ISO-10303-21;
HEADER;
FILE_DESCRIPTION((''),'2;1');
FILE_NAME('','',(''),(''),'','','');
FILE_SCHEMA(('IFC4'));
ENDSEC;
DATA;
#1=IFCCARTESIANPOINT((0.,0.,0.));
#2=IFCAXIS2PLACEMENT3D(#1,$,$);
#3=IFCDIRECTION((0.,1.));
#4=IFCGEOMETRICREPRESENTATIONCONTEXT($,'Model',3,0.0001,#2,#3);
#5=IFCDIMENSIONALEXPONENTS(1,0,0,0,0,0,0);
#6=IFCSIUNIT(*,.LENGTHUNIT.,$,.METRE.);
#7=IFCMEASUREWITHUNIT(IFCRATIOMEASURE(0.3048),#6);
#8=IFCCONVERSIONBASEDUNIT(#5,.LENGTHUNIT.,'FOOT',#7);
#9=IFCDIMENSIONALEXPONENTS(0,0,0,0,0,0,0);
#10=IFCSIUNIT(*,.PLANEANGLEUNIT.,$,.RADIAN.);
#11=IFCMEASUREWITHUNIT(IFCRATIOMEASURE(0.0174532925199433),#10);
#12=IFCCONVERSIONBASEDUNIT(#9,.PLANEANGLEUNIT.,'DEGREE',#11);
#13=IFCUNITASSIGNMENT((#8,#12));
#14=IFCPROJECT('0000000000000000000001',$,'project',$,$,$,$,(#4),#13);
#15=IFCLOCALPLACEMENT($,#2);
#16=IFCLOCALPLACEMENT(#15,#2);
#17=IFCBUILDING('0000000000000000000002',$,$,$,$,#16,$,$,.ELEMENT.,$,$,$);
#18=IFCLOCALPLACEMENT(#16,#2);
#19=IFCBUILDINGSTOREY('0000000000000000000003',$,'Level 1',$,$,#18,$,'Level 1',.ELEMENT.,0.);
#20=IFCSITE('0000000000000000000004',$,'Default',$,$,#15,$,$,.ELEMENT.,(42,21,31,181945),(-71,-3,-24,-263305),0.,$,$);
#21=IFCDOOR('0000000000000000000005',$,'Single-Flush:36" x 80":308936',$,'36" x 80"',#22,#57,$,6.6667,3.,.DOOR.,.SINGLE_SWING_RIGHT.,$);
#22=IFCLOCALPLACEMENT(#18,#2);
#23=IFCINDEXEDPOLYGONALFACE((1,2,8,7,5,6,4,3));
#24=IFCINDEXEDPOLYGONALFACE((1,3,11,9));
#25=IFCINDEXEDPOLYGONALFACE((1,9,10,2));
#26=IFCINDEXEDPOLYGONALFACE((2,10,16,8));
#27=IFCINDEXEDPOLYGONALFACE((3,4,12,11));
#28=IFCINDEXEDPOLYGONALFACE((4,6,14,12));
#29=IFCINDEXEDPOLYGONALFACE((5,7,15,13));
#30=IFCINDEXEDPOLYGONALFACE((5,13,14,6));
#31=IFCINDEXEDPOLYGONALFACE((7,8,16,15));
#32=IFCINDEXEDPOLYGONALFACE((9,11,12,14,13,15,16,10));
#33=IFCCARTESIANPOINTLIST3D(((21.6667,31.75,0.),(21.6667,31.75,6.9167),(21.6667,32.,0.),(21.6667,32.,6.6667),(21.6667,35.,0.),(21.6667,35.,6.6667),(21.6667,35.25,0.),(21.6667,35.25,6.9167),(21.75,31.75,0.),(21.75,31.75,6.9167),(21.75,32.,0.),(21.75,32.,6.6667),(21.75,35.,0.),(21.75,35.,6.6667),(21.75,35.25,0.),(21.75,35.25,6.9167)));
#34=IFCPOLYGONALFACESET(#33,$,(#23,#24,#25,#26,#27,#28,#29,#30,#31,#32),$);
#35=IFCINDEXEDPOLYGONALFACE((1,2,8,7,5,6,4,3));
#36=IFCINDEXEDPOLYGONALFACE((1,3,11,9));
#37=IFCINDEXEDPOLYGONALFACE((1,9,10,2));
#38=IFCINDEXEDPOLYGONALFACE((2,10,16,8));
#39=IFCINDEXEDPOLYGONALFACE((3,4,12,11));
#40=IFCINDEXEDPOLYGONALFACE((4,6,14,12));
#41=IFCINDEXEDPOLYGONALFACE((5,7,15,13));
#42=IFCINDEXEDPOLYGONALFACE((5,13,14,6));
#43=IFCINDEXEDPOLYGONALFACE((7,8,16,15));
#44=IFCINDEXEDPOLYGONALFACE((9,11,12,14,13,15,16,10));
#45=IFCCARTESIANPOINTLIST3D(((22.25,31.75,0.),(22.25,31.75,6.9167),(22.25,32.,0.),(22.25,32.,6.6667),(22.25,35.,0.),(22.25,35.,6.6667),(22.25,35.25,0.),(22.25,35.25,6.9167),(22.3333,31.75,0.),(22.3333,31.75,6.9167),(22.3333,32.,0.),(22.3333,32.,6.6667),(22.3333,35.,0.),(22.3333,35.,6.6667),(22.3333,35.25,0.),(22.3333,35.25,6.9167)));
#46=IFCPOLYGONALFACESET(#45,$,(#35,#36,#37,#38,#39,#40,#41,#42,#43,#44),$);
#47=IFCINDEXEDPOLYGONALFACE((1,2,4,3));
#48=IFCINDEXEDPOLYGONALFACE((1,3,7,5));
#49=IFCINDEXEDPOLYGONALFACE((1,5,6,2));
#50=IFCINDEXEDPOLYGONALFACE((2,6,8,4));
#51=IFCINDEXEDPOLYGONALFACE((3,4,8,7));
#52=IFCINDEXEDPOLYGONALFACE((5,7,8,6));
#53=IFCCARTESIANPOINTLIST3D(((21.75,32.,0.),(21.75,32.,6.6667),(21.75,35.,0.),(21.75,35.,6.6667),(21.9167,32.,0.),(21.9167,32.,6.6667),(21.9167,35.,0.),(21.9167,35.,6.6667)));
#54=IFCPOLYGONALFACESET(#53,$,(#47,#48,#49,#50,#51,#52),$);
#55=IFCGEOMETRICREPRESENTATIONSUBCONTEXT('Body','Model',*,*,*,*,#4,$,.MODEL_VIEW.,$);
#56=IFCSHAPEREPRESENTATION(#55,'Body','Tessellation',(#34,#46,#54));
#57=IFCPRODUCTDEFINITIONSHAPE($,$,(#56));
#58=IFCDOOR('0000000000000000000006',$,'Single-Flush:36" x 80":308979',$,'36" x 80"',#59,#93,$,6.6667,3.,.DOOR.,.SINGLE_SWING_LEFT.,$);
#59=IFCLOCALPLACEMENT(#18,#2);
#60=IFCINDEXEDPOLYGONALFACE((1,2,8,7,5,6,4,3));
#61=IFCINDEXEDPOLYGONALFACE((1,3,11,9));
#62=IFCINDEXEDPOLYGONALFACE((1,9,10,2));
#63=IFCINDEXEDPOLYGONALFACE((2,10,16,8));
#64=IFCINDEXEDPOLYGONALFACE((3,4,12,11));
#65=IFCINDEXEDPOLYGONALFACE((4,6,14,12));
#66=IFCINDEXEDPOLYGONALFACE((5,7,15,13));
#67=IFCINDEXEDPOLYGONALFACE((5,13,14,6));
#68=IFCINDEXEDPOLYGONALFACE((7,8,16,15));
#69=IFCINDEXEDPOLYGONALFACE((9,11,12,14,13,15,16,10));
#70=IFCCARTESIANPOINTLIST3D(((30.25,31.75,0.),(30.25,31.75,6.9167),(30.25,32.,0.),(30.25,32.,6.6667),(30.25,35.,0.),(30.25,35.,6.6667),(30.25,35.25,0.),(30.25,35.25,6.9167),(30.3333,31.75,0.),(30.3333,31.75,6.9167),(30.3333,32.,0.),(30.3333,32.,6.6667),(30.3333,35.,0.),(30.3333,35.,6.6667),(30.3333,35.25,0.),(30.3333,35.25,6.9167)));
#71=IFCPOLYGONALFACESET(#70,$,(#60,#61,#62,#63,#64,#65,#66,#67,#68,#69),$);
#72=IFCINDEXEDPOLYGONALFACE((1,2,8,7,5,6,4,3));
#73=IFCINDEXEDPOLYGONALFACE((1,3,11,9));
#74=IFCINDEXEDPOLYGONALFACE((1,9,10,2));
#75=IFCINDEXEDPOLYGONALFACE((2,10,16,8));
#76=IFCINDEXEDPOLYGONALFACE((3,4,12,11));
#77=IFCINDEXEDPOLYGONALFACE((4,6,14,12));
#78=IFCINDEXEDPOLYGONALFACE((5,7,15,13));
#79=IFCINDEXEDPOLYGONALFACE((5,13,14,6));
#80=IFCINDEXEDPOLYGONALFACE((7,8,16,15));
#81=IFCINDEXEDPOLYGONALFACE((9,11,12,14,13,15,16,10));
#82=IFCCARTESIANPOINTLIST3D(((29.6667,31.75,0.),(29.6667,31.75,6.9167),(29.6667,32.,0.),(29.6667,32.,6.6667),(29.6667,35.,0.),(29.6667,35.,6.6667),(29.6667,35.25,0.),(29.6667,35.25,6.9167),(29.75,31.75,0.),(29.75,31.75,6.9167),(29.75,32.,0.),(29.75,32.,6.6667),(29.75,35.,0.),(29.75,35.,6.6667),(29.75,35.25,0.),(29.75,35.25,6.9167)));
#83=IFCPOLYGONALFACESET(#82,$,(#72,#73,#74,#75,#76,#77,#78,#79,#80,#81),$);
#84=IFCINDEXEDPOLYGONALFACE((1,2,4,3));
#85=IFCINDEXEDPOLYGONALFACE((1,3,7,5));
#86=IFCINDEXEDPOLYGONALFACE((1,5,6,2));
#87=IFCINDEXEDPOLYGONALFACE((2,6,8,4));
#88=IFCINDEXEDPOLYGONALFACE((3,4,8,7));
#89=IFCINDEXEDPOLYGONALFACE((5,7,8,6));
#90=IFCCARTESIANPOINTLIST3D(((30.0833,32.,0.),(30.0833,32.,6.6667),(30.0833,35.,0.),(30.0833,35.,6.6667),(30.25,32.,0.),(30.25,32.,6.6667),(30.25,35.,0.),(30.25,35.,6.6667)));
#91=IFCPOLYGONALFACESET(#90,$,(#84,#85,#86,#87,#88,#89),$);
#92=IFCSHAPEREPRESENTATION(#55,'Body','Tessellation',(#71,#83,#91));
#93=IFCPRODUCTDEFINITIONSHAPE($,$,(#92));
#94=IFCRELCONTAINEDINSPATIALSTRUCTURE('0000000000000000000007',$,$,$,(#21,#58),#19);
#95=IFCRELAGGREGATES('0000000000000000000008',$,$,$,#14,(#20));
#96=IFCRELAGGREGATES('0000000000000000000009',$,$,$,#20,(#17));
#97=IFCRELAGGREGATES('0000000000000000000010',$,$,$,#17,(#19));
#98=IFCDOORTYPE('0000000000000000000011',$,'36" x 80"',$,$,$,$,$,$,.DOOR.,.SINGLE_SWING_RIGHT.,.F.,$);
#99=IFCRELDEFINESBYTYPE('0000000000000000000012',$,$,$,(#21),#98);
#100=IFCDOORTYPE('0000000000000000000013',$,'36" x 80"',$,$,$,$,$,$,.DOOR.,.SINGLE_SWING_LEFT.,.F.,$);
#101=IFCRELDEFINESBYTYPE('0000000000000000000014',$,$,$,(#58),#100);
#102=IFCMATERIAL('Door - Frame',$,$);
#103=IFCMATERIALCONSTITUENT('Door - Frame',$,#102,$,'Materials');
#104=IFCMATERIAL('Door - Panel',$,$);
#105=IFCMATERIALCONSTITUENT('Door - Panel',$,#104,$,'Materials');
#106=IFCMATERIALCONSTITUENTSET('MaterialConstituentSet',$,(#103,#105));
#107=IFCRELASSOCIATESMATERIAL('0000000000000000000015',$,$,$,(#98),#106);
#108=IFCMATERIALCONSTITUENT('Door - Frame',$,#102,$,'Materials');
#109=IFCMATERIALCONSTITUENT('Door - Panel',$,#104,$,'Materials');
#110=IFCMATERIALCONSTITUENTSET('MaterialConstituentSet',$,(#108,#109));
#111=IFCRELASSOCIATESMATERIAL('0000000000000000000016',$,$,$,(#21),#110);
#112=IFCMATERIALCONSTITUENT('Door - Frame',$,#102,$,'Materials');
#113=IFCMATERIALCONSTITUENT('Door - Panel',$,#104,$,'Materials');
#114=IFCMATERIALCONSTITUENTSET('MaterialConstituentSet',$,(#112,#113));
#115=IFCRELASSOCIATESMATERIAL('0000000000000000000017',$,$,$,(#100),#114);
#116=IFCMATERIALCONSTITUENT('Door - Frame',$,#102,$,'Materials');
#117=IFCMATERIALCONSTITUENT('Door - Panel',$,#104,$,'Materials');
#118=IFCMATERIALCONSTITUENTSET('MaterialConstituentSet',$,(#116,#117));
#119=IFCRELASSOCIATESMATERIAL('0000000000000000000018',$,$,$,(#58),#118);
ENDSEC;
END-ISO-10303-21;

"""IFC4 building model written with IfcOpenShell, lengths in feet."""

from ifc_helpers import new_model, entity, si_unit, converted_unit, direction, frame, origin, origin_2d_with_axis, place, context, subcontext, project, spatial, polyline, rectangle, outline, extrude, source, transform, mapped, material, constituent, constituent_set, type_object, type_shapes, element, save


model = new_model("IFC4")

# Units and contexts
model_context = context("Model", 3, precision=0.0001, world=origin(), true_north=direction((0.0, 1.0)))
body_context = subcontext(model_context, "Body", "Model", "MODEL_VIEW")
ifc_project = project(units=[converted_unit("LENGTHUNIT", "FOOT", entity("IfcRatioMeasure", 0.3048), si_unit("LENGTHUNIT", "METRE"), dimensions=[1, 0, 0, 0, 0, 0, 0]), converted_unit("PLANEANGLEUNIT", "DEGREE", entity("IfcRatioMeasure", 0.0174532925199433), si_unit("PLANEANGLEUNIT", "RADIAN"), dimensions=[0, 0, 0, 0, 0, 0, 0])], contexts=[model_context])

# Site, building, storey
site_placement = place(None, origin())
site = spatial("IfcSite", under=ifc_project, at=site_placement, Name="Default", CompositionType="ELEMENT", RefLatitude=(42, 21, 31, 181945), RefLongitude=(-71, -3, -24, -263305), RefElevation=0.0)
building_placement = place(site_placement, origin())
building = spatial("IfcBuilding", under=site, at=building_placement, CompositionType="ELEMENT")
storey_placement = place(building_placement, origin())
storey = spatial("IfcBuildingStorey", under=building, at=storey_placement, Name="Level 1", LongName="Level 1", CompositionType="ELEMENT", Elevation=0.0)

# Shared definitions
placement_1 = place(storey_placement, frame((30.0, 45.75, 0.0), z_axis=(0.0, 0.0, 1.0), x_axis=(0.0, -1.0, 0.0)))

# Shared definitions
placement_2 = place(storey_placement, frame((22.0, 45.75, 0.0), z_axis=(0.0, 0.0, 1.0), x_axis=(0.0, -1.0, 0.0)))

# Doors
ifc_material_1 = material(Name="Door - Frame")
ifc_constituent_1 = constituent(ifc_material_1, Name="Door - Frame", Category="Materials")
ifc_material_2 = material(Name="Door - Panel")
ifc_constituent_2 = constituent(ifc_material_2, Name="Door - Panel", Category="Materials")
ifc_constituent_set_1 = constituent_set(constituents=[ifc_constituent_1, ifc_constituent_2], Name="MaterialConstituentSet")
ifc_constituent_3 = constituent(ifc_material_1, Name="Door - Frame", Category="Materials")
ifc_constituent_4 = constituent(ifc_material_2, Name="Door - Panel", Category="Materials")
ifc_constituent_set_2 = constituent_set(constituents=[ifc_constituent_3, ifc_constituent_4], Name="MaterialConstituentSet")
door_type_1 = type_object("IfcDoorType", Name="36\" x 80\"", OperationType="SINGLE_SWING_RIGHT", ParameterTakesPrecedence=False, PredefinedType="DOOR", material=ifc_constituent_set_2)
shared_shape_1 = source(origin(), body_context, "Body", "SweptSolid", [
    extrude(outline(polyline([(-1.75, -3.5208), (1.75, -3.5208), (1.75, 3.3958), (1.5, 3.3958), (1.5, -3.2708), (-1.5, -3.2708), (-1.5, 3.3958), (-1.75, 3.3958), (-1.75, -3.5208)])), frame((1.5, 0.5, 3.3958), z_axis=(0.0, 1.0, 0.0), x_axis=(1.0, 0.0, 0.0)), (0.0, 0.0, 1.0), 0.0833),
    extrude(outline(polyline([(-3.5208, -1.75), (3.3958, -1.75), (3.3958, -1.5), (-3.2708, -1.5), (-3.2708, 1.5), (3.3958, 1.5), (3.3958, 1.75), (-3.5208, 1.75), (-3.5208, -1.75)])), frame((1.5, -0.0833, 3.3958), z_axis=(0.0, 1.0, 0.0), x_axis=(0.0, 0.0, -1.0)), (0.0, 0.0, 1.0), 0.0833),
    extrude(rectangle(XDim=0.1667, YDim=3.0, at=origin_2d_with_axis()), frame((1.5, 0.4167, 0.0), z_axis=(0.0, 0.0, 1.0), x_axis=(0.0, 1.0, 0.0)), (0.0, 0.0, 1.0), 6.6667),
])
type_shapes(door_type_1, [shared_shape_1])
placement_3 = place(placement_2, frame((13.75, 0.25, 0.0)))
door_1_placement = place(placement_3, frame((0.0, 0.0, 0.0), z_axis=(0.0, 0.0, 1.0), x_axis=(-1.0, 0.0, 0.0)))
element("IfcDoor", 1, at=door_1_placement, inside=storey, type_object=door_type_1, material=ifc_constituent_set_1, Name="Single-Flush:36\" x 80\":308936", ObjectType="36\" x 80\"", OperationType="SINGLE_SWING_RIGHT", OverallHeight=6.6667, OverallWidth=3.0, PredefinedType="DOOR", context=body_context, shape_type="MappedRepresentation", body=[
    mapped(shared_shape_1, transform((0.0, 0.0, 0.0), scale=1.0)),
])
ifc_constituent_5 = constituent(ifc_material_1, Name="Door - Frame", Category="Materials")
ifc_constituent_6 = constituent(ifc_material_2, Name="Door - Panel", Category="Materials")
ifc_constituent_set_3 = constituent_set(constituents=[ifc_constituent_5, ifc_constituent_6], Name="MaterialConstituentSet")
ifc_constituent_7 = constituent(ifc_material_1, Name="Door - Frame", Category="Materials")
ifc_constituent_8 = constituent(ifc_material_2, Name="Door - Panel", Category="Materials")
ifc_constituent_set_4 = constituent_set(constituents=[ifc_constituent_7, ifc_constituent_8], Name="MaterialConstituentSet")
door_type_2 = type_object("IfcDoorType", Name="36\" x 80\"", OperationType="SINGLE_SWING_LEFT", ParameterTakesPrecedence=False, PredefinedType="DOOR", material=ifc_constituent_set_4)
shared_shape_2 = source(origin(), body_context, "Body", "SweptSolid", [
    extrude(outline(polyline([(-1.75, -3.5208), (1.75, -3.5208), (1.75, 3.3958), (1.5, 3.3958), (1.5, -3.2708), (-1.5, -3.2708), (-1.5, 3.3958), (-1.75, 3.3958), (-1.75, -3.5208)])), frame((1.5, 0.5833, 3.3958), z_axis=(0.0, -1.0, 0.0), x_axis=(-1.0, 0.0, 0.0)), (0.0, 0.0, 1.0), 0.0833),
    extrude(outline(polyline([(-3.5208, -1.75), (3.3958, -1.75), (3.3958, -1.5), (-3.2708, -1.5), (-3.2708, 1.5), (3.3958, 1.5), (3.3958, 1.75), (-3.5208, 1.75), (-3.5208, -1.75)])), frame((1.5, 0.0, 3.3958), z_axis=(0.0, -1.0, 0.0), x_axis=(0.0, 0.0, -1.0)), (0.0, 0.0, 1.0), 0.0833),
    extrude(rectangle(XDim=3.0, YDim=0.1667, at=origin_2d_with_axis()), frame((1.5, 0.4167, 0.0)), (0.0, 0.0, 1.0), 6.6667),
])
type_shapes(door_type_2, [shared_shape_2])
placement_4 = place(placement_1, frame((10.75, -0.25, 0.0)))
door_2_placement = place(placement_4, origin())
element("IfcDoor", 2, at=door_2_placement, inside=storey, type_object=door_type_2, material=ifc_constituent_set_3, Name="Single-Flush:36\" x 80\":308979", ObjectType="36\" x 80\"", OperationType="SINGLE_SWING_LEFT", OverallHeight=6.6667, OverallWidth=3.0, PredefinedType="DOOR", context=body_context, shape_type="MappedRepresentation", body=[
    mapped(shared_shape_2, transform((0.0, 0.0, 0.0), scale=1.0)),
])

save(model, "model.ifc")
